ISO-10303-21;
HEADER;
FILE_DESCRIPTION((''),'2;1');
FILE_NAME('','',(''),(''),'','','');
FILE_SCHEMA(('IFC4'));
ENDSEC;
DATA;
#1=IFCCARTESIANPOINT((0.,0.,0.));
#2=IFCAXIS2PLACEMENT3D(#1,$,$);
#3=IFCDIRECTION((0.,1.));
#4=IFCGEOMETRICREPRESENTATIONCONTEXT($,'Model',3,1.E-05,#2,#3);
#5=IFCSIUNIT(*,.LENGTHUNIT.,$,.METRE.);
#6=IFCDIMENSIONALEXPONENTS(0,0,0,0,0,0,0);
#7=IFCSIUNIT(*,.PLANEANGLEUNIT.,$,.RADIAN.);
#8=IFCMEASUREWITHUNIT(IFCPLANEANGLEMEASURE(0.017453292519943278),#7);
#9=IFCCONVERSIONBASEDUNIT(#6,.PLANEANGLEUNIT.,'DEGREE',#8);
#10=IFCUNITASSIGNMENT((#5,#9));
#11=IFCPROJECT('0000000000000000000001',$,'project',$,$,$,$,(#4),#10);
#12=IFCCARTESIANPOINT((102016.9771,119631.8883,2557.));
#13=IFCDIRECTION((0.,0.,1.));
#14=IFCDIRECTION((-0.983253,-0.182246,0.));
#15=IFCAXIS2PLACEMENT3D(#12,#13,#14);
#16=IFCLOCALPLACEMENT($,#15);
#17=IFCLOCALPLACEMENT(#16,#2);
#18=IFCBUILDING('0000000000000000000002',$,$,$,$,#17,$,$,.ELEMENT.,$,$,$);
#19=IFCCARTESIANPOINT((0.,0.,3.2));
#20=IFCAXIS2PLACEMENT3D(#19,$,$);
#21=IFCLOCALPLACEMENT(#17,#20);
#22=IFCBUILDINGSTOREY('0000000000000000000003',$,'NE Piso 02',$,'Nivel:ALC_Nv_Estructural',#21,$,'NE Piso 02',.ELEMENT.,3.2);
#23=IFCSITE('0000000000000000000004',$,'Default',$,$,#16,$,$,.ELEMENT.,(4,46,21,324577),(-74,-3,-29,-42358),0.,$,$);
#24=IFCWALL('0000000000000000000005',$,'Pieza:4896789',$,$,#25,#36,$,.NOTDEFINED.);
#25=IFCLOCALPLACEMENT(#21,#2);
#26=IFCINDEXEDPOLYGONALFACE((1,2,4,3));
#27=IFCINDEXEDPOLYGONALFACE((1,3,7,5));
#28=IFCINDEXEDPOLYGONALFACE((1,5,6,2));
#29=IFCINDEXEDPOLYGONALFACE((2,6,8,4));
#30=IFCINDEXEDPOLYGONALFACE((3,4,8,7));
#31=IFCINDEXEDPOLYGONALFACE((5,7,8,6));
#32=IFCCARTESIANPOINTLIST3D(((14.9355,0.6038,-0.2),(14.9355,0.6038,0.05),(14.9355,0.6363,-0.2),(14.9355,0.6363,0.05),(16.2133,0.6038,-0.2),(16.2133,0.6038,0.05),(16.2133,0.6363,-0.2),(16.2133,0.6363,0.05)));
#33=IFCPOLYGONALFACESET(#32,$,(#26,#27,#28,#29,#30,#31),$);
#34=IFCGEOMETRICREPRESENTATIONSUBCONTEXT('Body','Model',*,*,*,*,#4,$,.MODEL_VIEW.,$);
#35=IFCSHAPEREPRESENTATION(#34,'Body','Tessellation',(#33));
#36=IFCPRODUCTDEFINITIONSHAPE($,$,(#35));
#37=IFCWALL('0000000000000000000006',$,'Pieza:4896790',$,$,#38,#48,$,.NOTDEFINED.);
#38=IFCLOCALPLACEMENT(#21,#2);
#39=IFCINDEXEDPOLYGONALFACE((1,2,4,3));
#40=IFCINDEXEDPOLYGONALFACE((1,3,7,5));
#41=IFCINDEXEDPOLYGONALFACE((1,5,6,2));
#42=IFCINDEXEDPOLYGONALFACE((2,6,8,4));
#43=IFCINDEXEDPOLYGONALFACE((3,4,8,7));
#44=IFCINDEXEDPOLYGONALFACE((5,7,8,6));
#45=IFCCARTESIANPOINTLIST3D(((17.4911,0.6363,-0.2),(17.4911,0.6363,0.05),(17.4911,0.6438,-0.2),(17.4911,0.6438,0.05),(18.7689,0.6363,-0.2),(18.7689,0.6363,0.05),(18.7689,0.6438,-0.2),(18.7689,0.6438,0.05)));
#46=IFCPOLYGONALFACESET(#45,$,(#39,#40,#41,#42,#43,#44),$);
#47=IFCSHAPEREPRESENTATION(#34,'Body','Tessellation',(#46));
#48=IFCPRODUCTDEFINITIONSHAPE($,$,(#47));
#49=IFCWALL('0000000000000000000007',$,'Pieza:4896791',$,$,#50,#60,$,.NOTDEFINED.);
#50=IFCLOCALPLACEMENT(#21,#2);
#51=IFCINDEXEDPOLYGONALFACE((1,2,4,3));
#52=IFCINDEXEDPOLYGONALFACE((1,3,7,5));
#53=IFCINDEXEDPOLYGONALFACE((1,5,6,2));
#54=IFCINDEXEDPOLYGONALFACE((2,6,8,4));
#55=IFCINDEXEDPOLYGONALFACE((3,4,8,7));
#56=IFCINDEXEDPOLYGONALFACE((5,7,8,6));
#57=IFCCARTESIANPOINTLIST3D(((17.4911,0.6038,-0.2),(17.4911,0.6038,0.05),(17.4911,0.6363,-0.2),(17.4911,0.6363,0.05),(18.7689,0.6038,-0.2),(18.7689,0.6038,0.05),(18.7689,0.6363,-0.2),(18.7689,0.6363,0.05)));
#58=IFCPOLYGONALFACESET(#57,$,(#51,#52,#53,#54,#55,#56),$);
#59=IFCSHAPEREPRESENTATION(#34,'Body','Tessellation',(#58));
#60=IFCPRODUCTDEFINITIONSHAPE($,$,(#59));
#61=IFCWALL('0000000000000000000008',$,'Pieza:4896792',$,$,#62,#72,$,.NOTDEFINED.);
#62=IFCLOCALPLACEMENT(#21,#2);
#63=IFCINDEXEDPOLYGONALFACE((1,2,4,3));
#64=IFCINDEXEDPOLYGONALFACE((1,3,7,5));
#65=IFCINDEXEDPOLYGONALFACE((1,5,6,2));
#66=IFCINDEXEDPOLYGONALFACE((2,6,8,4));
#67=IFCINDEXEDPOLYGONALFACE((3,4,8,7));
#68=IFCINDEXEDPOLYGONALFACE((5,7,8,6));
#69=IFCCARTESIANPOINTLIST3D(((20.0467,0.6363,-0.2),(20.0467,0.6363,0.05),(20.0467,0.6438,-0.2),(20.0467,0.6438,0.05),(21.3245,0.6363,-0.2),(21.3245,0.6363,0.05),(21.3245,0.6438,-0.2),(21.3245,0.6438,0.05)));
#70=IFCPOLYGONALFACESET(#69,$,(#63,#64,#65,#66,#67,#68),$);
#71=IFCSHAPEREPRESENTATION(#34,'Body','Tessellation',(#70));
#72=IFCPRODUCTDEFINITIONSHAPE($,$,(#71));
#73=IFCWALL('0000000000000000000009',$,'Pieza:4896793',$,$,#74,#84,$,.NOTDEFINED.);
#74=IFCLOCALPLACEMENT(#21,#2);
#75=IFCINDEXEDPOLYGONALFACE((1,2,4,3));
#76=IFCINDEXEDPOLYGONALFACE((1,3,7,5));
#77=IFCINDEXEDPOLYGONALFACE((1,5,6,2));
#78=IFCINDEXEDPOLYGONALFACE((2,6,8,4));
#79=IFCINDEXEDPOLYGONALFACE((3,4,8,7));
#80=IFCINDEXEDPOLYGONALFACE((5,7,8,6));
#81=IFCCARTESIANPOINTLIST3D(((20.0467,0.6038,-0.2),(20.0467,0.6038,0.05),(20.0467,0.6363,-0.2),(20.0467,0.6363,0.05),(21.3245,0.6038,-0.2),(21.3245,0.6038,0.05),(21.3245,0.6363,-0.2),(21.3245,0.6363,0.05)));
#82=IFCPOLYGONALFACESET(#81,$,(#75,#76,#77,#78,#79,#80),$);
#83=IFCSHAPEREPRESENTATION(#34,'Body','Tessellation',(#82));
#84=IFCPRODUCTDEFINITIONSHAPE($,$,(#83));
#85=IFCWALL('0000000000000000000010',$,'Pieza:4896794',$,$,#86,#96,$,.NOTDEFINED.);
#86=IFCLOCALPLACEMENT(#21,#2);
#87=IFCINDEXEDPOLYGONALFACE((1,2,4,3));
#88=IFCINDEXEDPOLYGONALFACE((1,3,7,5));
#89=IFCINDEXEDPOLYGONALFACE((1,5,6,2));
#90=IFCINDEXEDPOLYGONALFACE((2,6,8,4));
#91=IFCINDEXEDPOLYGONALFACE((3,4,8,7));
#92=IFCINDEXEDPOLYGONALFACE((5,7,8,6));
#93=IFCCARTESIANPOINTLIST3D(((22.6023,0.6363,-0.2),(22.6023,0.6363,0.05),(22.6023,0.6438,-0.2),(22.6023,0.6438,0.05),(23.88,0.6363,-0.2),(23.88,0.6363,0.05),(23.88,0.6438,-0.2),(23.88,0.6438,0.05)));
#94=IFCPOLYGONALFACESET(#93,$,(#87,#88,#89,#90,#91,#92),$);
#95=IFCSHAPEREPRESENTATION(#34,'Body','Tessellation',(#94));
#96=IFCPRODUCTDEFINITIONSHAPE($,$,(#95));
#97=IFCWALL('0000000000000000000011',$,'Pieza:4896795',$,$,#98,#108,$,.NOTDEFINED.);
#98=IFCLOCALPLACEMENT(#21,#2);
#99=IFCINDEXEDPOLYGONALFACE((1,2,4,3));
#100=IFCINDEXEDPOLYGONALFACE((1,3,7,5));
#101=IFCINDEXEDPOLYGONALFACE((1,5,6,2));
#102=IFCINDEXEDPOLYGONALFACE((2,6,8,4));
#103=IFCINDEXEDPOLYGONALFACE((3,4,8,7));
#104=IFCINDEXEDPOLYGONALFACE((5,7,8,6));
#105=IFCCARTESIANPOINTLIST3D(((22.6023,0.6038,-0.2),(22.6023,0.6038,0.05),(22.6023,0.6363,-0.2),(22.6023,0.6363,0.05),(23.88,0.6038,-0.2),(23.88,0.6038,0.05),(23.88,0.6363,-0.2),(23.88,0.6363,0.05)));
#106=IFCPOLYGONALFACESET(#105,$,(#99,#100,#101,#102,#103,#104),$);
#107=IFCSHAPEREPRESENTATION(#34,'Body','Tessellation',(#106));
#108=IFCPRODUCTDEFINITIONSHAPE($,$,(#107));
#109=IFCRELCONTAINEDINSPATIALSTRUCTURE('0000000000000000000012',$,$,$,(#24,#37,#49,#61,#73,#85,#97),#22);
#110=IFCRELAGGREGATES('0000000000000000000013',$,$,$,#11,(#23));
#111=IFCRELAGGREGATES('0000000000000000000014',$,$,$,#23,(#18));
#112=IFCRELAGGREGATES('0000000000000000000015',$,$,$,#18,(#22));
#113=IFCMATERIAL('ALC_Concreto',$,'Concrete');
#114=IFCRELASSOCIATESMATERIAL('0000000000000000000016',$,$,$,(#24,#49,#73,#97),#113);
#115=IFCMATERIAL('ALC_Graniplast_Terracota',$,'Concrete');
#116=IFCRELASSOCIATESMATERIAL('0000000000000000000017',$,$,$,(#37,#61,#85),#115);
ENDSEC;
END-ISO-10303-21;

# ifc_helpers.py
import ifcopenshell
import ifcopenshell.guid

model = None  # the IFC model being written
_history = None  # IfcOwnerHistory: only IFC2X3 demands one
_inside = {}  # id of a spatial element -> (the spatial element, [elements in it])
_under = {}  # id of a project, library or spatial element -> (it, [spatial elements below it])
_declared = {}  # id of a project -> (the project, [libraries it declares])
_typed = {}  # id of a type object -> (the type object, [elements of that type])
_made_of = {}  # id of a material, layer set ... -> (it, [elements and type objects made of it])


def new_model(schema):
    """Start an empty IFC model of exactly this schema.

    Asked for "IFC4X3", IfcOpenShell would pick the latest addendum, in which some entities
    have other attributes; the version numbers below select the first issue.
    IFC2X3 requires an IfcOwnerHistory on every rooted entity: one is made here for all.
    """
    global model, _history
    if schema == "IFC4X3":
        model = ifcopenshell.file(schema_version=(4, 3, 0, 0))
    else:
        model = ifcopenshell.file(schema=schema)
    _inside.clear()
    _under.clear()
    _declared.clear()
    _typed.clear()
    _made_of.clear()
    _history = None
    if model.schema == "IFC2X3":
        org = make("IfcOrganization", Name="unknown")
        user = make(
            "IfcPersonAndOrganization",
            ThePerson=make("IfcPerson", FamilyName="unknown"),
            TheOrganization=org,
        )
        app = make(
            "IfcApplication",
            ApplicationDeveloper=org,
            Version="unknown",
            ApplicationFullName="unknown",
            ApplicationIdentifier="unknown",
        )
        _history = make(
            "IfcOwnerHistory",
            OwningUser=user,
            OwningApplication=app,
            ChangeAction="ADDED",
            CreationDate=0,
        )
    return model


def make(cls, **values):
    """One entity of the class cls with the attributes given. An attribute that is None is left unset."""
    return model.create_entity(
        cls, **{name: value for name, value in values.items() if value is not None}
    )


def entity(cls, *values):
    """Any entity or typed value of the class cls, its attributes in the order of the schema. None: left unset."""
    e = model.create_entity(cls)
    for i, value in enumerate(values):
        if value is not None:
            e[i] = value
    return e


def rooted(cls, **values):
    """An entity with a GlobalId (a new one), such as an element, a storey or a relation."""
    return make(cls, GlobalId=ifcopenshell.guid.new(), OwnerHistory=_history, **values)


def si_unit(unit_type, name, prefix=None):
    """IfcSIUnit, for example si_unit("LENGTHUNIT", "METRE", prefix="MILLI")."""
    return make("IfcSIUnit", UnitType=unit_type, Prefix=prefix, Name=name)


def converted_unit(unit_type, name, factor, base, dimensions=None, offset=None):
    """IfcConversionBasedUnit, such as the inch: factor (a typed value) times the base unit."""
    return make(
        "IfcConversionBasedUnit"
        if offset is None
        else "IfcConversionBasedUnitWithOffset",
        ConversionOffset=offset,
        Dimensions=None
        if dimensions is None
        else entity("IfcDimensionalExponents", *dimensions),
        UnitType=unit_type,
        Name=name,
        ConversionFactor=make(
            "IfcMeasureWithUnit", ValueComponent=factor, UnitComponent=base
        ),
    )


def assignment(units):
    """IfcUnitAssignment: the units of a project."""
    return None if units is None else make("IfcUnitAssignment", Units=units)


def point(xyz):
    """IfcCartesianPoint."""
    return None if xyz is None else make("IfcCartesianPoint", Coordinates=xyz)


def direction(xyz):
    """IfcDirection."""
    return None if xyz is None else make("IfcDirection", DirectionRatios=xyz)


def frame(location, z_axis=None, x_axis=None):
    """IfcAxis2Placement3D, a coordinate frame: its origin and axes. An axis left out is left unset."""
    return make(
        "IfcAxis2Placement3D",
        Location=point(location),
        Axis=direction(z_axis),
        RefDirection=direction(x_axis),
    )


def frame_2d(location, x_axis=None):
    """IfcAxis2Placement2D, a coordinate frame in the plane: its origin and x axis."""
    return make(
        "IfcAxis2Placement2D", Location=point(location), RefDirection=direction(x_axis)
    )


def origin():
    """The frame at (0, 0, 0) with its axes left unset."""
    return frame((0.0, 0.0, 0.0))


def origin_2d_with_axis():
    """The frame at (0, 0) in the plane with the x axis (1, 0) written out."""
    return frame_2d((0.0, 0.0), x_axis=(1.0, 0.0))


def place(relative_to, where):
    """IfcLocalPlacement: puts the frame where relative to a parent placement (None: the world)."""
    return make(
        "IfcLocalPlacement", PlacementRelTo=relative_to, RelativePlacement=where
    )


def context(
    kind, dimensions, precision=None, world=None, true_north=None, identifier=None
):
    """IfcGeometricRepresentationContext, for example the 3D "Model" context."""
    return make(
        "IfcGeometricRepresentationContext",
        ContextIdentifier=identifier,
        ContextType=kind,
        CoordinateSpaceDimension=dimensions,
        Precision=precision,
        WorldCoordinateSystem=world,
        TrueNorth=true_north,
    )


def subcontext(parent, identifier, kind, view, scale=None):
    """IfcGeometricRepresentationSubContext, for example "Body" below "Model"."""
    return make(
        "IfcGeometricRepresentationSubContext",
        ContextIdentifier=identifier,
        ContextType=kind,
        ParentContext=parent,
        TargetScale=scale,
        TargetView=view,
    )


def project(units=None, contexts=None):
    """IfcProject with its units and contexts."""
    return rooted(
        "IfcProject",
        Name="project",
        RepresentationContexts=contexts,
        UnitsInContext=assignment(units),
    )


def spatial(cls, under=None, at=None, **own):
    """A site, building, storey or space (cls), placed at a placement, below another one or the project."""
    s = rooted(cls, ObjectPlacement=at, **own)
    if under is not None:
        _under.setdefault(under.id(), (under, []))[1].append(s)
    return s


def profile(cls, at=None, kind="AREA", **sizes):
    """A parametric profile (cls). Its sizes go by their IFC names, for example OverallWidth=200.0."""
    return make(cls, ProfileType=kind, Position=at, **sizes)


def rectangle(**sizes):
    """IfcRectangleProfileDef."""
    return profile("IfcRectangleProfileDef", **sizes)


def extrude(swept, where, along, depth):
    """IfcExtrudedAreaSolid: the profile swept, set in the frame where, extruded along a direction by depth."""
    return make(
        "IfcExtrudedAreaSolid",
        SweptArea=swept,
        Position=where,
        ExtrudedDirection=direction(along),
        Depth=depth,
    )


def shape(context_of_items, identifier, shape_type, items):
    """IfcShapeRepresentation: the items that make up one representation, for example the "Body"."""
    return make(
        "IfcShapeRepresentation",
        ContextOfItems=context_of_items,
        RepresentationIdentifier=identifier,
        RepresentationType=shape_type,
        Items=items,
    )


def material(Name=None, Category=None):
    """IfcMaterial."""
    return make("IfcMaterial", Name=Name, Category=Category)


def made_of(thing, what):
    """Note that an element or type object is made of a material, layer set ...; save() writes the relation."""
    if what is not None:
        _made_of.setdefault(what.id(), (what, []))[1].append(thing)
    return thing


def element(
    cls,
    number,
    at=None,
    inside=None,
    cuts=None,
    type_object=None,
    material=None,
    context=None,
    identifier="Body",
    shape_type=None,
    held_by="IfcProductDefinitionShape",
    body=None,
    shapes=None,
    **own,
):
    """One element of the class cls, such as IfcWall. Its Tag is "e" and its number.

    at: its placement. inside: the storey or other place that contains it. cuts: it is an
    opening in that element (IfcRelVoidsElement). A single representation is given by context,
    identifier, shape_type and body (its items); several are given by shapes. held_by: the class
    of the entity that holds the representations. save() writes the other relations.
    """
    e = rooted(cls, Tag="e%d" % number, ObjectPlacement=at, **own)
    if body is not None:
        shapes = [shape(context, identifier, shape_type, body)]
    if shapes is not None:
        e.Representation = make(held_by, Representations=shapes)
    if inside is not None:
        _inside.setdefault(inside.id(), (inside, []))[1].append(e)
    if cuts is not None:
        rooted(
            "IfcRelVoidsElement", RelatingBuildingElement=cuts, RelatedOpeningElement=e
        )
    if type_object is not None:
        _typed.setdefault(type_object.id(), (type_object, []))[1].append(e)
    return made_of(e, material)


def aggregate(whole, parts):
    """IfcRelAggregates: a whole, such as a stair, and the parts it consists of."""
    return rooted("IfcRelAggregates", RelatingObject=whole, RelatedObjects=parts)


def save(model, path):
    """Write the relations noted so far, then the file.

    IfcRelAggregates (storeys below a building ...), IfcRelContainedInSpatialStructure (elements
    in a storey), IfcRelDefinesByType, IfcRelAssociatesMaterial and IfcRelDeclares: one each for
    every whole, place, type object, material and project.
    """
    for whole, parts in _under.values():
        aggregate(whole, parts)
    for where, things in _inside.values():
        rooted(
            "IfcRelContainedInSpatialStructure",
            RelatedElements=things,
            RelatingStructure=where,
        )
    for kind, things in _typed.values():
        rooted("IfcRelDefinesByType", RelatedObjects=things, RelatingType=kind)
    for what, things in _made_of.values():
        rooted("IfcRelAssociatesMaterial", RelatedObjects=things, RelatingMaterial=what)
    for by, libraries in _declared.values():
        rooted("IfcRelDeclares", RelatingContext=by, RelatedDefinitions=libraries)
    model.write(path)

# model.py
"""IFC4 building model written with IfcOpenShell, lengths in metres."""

from ifc_helpers import new_model, entity, si_unit, converted_unit, direction, frame, frame_2d, origin, origin_2d_with_axis, place, context, subcontext, project, spatial, rectangle, extrude, material, element, save


model = new_model("IFC4")

# Units and contexts
model_context = context("Model", 3, precision=1e-05, world=origin(), true_north=direction((0.0, 1.0)))
body_context = subcontext(model_context, "Body", "Model", "MODEL_VIEW")
ifc_project = project(units=[si_unit("LENGTHUNIT", "METRE"), converted_unit("PLANEANGLEUNIT", "DEGREE", entity("IfcPlaneAngleMeasure", 0.017453292519943278), si_unit("PLANEANGLEUNIT", "RADIAN"), dimensions=[0, 0, 0, 0, 0, 0, 0])], contexts=[model_context])

# Site, building, storey
site_placement = place(None, frame((102016.9771, 119631.8883, 2557.0), z_axis=(0.0, 0.0, 1.0), x_axis=(-0.983253, -0.182246, 0.0)))
site = spatial("IfcSite", under=ifc_project, at=site_placement, Name="Default", CompositionType="ELEMENT", RefLatitude=(4, 46, 21, 324577), RefLongitude=(-74, -3, -29, -42358), RefElevation=0.0)
building_placement = place(site_placement, origin())
building = spatial("IfcBuilding", under=site, at=building_placement, CompositionType="ELEMENT")
storey_placement = place(building_placement, frame((0.0, 0.0, 3.2)))
storey = spatial("IfcBuildingStorey", under=building, at=storey_placement, Name="NE Piso 02", ObjectType="Nivel:ALC_Nv_Estructural", LongName="NE Piso 02", CompositionType="ELEMENT", Elevation=3.2)

# Walls
ifc_material_1 = material(Name="ALC_Concreto", Category="Concrete")
ifc_material_2 = material(Name="ALC_Graniplast_Terracota", Category="Concrete")
wall_1_placement = place(storey_placement, frame((0.0, 0.0, -0.2)))
element("IfcWall", 1, at=wall_1_placement, inside=storey, material=ifc_material_1, Name="Pieza:4896789", PredefinedType="NOTDEFINED", context=body_context, shape_type="SweptSolid", body=[
    extrude(rectangle(XDim=0.0325, YDim=1.2778, at=origin_2d_with_axis()), frame((15.5744, 0.6201, 0.0), z_axis=(0.0, 0.0, 1.0), x_axis=(0.0, -1.0, 0.0)), (0.0, 0.0, 1.0), 0.25),
])
wall_2_placement = place(storey_placement, frame((0.0, 0.0, -0.2)))
element("IfcWall", 2, at=wall_2_placement, inside=storey, material=ifc_material_2, Name="Pieza:4896790", PredefinedType="NOTDEFINED", context=body_context, shape_type="SweptSolid", body=[
    extrude(rectangle(XDim=0.0075, YDim=1.2778, at=frame_2d((0.0, 0.0), x_axis=(1.0, 0.0))), frame((18.13, 0.6401, 0.0), z_axis=(0.0, 0.0, 1.0), x_axis=(0.0, -1.0, 0.0)), (0.0, 0.0, 1.0), 0.25),
])
wall_3_placement = place(storey_placement, frame((0.0, 0.0, -0.2)))
element("IfcWall", 3, at=wall_3_placement, inside=storey, material=ifc_material_1, Name="Pieza:4896791", PredefinedType="NOTDEFINED", context=body_context, shape_type="SweptSolid", body=[
    extrude(rectangle(XDim=0.0325, YDim=1.2778, at=frame_2d((0.0, 0.0), x_axis=(1.0, 0.0))), frame((18.13, 0.6201, 0.0), z_axis=(0.0, 0.0, 1.0), x_axis=(0.0, -1.0, 0.0)), (0.0, 0.0, 1.0), 0.25),
])
wall_4_placement = place(storey_placement, frame((0.0, 0.0, -0.2)))
element("IfcWall", 4, at=wall_4_placement, inside=storey, material=ifc_material_2, Name="Pieza:4896792", PredefinedType="NOTDEFINED", context=body_context, shape_type="SweptSolid", body=[
    extrude(rectangle(XDim=0.0075, YDim=1.2778, at=frame_2d((0.0, 0.0), x_axis=(1.0, 0.0))), frame((20.6856, 0.6401, 0.0), z_axis=(0.0, 0.0, 1.0), x_axis=(0.0, -1.0, 0.0)), (0.0, 0.0, 1.0), 0.25),
])
wall_5_placement = place(storey_placement, frame((0.0, 0.0, -0.2)))
element("IfcWall", 5, at=wall_5_placement, inside=storey, material=ifc_material_1, Name="Pieza:4896793", PredefinedType="NOTDEFINED", context=body_context, shape_type="SweptSolid", body=[
    extrude(rectangle(XDim=0.0325, YDim=1.2778, at=origin_2d_with_axis()), frame((20.6856, 0.6201, 0.0), z_axis=(0.0, 0.0, 1.0), x_axis=(0.0, -1.0, 0.0)), (0.0, 0.0, 1.0), 0.25),
])
wall_6_placement = place(storey_placement, frame((0.0, 0.0, -0.2)))
element("IfcWall", 6, at=wall_6_placement, inside=storey, material=ifc_material_2, Name="Pieza:4896794", PredefinedType="NOTDEFINED", context=body_context, shape_type="SweptSolid", body=[
    extrude(rectangle(XDim=0.0075, YDim=1.2778, at=frame_2d((0.0, 0.0), x_axis=(1.0, 0.0))), frame((23.2412, 0.6401, 0.0), z_axis=(0.0, 0.0, 1.0), x_axis=(0.0, -1.0, 0.0)), (0.0, 0.0, 1.0), 0.25),
])
wall_7_placement = place(storey_placement, frame((0.0, 0.0, -0.2)))
element("IfcWall", 7, at=wall_7_placement, inside=storey, material=ifc_material_1, Name="Pieza:4896795", PredefinedType="NOTDEFINED", context=body_context, shape_type="SweptSolid", body=[
    extrude(rectangle(XDim=0.0325, YDim=1.2778, at=origin_2d_with_axis()), frame((23.2412, 0.6201, 0.0), z_axis=(0.0, 0.0, 1.0), x_axis=(0.0, -1.0, 0.0)), (0.0, 0.0, 1.0), 0.25),
])

save(model, "model.ifc")
